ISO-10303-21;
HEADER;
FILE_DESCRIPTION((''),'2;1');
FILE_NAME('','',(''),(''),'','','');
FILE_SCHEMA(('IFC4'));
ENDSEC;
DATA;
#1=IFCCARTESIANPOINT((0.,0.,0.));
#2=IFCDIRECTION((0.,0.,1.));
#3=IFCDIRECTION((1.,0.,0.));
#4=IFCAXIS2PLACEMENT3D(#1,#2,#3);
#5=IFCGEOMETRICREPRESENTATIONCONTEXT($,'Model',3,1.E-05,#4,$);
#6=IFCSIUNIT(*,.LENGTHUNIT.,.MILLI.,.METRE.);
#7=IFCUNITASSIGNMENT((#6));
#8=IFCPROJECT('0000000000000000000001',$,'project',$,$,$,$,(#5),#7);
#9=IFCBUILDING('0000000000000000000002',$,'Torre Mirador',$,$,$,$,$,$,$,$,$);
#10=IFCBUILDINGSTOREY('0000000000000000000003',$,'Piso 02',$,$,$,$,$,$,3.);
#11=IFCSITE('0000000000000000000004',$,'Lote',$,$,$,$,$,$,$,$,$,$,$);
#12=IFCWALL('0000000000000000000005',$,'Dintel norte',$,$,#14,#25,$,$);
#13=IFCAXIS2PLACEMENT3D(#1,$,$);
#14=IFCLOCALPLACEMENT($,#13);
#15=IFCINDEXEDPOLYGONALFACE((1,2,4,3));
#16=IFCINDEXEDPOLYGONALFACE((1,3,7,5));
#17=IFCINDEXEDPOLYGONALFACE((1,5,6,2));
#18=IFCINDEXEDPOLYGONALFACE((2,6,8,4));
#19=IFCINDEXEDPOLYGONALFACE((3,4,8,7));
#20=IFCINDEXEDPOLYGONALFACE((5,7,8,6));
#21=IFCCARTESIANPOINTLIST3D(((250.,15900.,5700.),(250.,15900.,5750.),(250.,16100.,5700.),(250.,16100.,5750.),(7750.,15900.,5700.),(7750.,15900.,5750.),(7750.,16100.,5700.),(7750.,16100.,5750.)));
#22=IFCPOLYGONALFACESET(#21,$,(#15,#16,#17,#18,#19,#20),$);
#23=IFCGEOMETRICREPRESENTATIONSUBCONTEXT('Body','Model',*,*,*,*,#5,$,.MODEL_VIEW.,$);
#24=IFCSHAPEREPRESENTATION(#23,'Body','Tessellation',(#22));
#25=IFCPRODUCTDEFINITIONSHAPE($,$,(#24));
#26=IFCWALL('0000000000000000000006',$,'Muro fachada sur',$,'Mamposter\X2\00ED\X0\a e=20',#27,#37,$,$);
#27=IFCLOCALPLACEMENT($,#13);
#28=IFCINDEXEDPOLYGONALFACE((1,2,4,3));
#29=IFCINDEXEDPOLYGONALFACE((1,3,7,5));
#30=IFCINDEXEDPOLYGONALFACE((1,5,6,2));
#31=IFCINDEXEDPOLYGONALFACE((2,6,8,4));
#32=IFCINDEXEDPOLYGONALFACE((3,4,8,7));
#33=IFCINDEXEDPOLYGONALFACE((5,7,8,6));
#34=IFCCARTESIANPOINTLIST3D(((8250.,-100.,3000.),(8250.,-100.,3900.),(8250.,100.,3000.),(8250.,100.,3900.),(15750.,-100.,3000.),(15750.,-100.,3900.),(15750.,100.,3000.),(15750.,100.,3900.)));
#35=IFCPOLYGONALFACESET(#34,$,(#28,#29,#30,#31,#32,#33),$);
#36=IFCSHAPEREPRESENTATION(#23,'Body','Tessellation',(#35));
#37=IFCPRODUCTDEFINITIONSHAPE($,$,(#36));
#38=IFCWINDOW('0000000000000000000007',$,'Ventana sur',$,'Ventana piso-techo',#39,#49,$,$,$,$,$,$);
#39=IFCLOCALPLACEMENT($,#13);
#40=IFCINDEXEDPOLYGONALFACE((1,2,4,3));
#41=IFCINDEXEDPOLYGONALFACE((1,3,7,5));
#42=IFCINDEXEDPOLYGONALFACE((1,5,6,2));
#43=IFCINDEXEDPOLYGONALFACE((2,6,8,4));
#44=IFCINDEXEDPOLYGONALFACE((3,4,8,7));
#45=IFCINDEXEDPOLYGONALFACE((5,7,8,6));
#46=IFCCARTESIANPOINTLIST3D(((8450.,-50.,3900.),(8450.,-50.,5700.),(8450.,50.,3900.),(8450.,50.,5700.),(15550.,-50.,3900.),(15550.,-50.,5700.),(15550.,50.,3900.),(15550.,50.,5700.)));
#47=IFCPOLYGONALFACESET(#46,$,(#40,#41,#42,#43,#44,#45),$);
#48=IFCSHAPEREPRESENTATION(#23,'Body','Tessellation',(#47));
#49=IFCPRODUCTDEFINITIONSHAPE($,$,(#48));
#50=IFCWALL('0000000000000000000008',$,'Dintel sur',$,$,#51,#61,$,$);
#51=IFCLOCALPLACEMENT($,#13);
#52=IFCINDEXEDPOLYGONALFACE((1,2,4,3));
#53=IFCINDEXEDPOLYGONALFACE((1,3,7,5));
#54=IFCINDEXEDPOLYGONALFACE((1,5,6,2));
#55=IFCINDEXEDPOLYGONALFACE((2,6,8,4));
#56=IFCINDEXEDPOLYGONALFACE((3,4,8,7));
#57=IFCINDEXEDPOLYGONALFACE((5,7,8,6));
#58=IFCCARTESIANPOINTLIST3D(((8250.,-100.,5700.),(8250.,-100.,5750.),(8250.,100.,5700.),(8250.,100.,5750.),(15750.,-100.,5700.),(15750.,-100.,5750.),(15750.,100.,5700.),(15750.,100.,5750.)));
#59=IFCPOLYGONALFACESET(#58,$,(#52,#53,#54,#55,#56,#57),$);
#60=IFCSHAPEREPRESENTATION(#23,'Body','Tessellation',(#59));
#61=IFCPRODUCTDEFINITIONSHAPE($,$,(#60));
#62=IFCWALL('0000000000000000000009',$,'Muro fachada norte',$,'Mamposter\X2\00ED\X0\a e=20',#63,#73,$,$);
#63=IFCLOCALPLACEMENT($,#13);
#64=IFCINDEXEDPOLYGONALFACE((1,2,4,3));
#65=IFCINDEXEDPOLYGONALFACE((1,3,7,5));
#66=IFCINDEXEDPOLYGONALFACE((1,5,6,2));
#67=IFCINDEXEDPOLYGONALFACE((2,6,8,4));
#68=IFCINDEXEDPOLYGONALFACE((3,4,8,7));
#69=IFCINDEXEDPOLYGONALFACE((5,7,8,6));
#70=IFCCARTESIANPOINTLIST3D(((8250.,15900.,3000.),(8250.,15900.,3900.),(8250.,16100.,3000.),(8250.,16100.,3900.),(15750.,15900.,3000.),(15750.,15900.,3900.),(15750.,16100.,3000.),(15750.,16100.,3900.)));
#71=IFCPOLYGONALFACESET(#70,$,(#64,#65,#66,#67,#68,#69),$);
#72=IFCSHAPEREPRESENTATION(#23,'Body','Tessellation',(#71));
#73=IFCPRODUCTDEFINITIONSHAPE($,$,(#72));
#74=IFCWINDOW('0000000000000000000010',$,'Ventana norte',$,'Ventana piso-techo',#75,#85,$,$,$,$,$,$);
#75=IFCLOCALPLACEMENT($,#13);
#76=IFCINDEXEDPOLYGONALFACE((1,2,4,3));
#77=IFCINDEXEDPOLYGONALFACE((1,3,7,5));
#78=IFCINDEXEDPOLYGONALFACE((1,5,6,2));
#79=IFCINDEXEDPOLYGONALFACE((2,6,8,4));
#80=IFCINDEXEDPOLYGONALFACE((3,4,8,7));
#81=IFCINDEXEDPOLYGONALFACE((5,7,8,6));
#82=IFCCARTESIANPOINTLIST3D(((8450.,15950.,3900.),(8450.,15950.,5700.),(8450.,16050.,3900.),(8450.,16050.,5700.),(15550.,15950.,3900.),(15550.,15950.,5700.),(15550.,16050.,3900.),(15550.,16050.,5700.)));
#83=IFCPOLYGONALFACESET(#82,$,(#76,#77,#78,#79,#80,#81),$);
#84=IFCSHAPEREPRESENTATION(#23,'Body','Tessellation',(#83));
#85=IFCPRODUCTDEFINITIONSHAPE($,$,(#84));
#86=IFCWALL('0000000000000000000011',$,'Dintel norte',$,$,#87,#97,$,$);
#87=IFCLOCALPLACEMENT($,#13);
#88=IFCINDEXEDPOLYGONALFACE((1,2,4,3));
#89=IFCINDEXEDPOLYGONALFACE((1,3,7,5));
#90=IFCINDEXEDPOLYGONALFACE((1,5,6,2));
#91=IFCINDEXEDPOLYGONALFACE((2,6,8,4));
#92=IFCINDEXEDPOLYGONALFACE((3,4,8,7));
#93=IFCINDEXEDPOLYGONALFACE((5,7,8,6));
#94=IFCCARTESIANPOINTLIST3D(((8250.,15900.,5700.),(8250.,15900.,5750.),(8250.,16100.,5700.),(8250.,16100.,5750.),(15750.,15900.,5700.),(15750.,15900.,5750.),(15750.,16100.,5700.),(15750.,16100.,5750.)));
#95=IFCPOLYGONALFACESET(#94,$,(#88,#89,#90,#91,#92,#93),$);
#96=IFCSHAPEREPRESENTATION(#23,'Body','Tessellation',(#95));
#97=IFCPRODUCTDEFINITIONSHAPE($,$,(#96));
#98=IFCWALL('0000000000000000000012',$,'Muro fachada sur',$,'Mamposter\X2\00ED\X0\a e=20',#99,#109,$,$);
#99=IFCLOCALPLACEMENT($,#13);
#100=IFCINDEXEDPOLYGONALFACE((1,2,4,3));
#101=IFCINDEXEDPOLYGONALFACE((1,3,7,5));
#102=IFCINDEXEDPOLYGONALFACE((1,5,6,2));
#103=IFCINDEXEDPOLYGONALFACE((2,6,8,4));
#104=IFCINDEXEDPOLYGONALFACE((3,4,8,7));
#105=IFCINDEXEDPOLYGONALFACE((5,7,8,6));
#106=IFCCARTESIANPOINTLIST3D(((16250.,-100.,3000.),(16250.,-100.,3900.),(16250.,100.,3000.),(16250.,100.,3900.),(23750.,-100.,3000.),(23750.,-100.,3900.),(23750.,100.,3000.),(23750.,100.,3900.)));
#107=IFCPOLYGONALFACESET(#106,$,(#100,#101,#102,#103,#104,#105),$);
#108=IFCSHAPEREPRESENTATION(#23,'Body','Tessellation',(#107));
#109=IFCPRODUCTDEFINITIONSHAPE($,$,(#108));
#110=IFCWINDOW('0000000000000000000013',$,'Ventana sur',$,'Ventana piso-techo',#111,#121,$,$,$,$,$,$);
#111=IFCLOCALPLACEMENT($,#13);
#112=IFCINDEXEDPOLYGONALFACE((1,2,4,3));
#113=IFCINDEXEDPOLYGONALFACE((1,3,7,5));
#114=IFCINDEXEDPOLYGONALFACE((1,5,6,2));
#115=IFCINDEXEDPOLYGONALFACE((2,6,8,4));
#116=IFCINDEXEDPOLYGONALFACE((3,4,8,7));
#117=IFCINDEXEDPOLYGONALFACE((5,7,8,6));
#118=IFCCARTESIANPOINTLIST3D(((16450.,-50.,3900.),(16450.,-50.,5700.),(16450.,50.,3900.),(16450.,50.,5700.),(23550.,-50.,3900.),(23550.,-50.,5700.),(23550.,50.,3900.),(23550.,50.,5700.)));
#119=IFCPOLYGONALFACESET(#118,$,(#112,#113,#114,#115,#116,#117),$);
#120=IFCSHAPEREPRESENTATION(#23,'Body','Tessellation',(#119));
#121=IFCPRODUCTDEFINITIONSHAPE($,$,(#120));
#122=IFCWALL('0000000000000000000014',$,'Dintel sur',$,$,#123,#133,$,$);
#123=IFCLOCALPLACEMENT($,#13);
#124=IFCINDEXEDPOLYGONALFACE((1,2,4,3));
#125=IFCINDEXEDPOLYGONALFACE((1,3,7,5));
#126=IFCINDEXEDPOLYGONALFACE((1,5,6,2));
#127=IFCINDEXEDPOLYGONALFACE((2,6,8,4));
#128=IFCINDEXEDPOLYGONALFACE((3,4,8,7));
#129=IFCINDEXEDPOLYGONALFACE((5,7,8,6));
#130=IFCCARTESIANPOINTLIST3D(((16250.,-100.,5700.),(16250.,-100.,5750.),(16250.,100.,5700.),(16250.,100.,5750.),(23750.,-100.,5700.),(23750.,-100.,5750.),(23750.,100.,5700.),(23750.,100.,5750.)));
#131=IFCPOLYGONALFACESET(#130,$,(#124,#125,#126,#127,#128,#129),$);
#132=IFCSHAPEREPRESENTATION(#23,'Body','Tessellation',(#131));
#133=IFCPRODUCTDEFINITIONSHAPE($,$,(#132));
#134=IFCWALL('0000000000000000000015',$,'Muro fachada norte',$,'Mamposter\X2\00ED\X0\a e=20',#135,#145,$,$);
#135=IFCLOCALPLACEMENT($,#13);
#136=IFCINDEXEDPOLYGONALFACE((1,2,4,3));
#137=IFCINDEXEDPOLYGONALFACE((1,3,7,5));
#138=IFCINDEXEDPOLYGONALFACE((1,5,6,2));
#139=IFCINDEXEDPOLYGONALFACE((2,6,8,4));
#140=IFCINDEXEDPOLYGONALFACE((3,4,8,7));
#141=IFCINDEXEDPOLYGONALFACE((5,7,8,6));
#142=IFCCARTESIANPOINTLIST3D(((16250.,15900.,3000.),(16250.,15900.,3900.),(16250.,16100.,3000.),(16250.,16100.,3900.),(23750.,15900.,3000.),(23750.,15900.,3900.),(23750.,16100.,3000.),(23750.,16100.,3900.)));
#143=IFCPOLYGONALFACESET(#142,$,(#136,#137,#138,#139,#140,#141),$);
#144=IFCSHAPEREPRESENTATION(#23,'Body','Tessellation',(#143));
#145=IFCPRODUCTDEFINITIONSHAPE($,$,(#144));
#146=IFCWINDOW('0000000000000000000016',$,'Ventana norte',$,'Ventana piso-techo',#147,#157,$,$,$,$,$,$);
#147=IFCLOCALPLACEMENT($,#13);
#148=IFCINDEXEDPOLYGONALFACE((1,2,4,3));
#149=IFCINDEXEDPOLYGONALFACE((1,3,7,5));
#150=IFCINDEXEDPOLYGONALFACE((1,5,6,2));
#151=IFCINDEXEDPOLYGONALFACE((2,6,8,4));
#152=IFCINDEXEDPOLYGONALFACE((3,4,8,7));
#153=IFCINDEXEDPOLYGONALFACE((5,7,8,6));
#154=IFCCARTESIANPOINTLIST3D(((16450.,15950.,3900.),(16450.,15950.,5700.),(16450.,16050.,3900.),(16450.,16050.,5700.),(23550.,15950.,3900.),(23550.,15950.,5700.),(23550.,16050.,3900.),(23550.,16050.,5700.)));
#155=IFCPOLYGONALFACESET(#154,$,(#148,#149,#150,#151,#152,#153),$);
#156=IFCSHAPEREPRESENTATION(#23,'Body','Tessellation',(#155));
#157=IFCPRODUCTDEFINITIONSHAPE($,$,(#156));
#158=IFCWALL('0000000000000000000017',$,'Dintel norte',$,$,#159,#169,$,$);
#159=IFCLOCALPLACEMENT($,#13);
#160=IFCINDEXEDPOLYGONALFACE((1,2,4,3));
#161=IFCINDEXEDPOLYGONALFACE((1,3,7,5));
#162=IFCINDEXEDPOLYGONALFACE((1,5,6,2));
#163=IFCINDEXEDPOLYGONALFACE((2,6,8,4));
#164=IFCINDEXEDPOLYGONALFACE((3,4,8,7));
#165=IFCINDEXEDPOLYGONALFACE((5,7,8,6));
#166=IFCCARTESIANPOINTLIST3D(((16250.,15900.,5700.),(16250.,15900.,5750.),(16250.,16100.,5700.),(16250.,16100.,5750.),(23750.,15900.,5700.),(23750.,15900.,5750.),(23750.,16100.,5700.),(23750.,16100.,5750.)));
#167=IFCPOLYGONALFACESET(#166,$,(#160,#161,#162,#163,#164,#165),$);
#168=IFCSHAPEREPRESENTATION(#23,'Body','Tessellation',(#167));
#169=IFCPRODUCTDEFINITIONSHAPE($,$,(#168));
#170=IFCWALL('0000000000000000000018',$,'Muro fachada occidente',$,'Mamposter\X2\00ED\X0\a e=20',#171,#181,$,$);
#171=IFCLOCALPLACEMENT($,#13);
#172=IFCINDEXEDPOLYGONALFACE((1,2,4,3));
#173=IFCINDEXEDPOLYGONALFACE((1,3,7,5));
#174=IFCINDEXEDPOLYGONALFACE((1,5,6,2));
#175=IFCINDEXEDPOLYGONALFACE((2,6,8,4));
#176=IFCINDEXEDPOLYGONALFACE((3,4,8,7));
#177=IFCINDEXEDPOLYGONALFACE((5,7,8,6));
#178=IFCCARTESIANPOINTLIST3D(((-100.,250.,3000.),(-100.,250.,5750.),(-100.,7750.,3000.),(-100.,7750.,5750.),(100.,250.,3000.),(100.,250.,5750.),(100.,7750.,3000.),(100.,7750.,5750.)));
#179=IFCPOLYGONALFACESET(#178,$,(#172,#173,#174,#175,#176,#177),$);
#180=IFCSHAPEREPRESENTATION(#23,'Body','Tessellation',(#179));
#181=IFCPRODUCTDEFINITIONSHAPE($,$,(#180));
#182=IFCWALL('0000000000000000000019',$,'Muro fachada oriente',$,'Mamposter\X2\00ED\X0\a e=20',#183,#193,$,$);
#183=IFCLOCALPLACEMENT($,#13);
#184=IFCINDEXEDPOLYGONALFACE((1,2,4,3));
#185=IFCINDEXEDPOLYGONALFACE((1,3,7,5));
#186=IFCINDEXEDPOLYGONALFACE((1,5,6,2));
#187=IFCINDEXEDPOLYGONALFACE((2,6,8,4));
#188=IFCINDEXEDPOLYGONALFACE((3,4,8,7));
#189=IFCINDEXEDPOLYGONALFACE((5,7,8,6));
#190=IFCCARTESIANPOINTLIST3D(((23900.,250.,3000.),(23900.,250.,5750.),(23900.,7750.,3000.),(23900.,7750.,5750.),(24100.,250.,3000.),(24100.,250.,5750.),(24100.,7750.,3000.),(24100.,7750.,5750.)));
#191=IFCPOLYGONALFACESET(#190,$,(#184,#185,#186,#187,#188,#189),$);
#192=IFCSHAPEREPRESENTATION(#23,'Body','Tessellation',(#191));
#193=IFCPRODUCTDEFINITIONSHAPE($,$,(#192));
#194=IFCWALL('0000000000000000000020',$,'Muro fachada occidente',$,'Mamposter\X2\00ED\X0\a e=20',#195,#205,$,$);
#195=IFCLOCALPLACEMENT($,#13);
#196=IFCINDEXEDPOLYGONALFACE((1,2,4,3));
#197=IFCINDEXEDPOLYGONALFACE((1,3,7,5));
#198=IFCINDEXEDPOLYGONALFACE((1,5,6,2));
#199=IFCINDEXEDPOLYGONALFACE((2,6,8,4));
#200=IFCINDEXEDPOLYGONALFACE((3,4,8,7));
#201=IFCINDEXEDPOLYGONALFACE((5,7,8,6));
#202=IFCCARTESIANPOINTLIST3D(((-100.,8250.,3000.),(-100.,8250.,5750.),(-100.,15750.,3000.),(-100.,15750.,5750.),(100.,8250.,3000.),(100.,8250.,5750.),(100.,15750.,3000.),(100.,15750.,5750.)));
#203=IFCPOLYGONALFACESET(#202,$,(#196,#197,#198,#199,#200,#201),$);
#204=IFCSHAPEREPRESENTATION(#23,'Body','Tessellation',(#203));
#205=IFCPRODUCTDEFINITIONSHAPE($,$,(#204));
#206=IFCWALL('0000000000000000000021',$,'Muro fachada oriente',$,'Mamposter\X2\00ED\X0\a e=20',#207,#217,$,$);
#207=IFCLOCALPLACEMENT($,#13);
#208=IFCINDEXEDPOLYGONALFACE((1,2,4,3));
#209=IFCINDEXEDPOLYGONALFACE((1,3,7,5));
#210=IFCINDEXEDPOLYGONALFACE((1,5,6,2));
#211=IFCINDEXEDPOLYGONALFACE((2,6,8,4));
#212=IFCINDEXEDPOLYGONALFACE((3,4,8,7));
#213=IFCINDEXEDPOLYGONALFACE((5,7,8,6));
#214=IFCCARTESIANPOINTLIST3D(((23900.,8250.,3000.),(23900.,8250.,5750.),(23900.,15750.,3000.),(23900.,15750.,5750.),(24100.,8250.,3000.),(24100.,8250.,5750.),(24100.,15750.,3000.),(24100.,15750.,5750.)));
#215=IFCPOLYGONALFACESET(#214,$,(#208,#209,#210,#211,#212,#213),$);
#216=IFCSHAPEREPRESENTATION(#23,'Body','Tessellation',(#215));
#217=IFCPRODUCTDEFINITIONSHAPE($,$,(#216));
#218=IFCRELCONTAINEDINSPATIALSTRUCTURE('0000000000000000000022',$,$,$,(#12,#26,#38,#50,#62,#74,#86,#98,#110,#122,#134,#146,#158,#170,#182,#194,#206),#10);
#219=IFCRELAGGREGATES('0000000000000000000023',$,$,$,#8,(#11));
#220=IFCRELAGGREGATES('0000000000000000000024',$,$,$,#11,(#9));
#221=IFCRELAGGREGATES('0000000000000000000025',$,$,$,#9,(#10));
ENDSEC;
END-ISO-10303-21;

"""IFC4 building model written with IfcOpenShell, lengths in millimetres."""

from ifc_helpers import new_model, si_unit, frame, origin_with_axes, place, context, subcontext, project, spatial, indexed_curve, outline, extrude, element, save


model = new_model("IFC4")

# Units and contexts
model_context = context("Model", 3, precision=1e-05, world=origin_with_axes())
body_context = subcontext(model_context, "Body", "Model", "MODEL_VIEW")
ifc_project = project(units=[si_unit("LENGTHUNIT", "METRE", prefix="MILLI")], contexts=[model_context])

# Site, building, storey
site = spatial("IfcSite", under=ifc_project, Name="Lote")
building = spatial("IfcBuilding", under=site, Name="Torre Mirador")
storey = spatial("IfcBuildingStorey", under=building, Name="Piso 02", Elevation=3.0)

# Walls
wall_1_placement = place(None, frame((250.0, 15900.0, 5700.0), z_axis=(0.0, 0.0, 1.0), x_axis=(1.0, 0.0, 0.0)))
element("IfcWall", 1, at=wall_1_placement, inside=storey, Name="Dintel norte", context=body_context, shape_type="SweptSolid", body=[
    extrude(outline(indexed_curve([(0.0, 0.0), (0.0, 200.0), (7500.0, 200.0), (7500.0, 0.0), (0.0, 0.0)], self_intersect=False)), origin_with_axes(), (0.0, 0.0, 1.0), 50.0),
])
wall_2_placement = place(None, frame((8250.0, -100.0, 3000.0), z_axis=(0.0, 0.0, 1.0), x_axis=(1.0, 0.0, 0.0)))
element("IfcWall", 2, at=wall_2_placement, inside=storey, Name="Muro fachada sur", ObjectType="Mampostería e=20", context=body_context, shape_type="SweptSolid", body=[
    extrude(outline(indexed_curve([(0.0, 0.0), (0.0, 200.0), (7500.0, 200.0), (7500.0, 0.0), (0.0, 0.0)], self_intersect=False)), origin_with_axes(), (0.0, 0.0, 1.0), 900.0),
])

# Window
window_1_placement = place(None, frame((8450.0, -50.0, 3900.0), z_axis=(0.0, 0.0, 1.0), x_axis=(1.0, 0.0, 0.0)))
element("IfcWindow", 3, at=window_1_placement, inside=storey, Name="Ventana sur", ObjectType="Ventana piso-techo", context=body_context, shape_type="SweptSolid", body=[
    extrude(outline(indexed_curve([(0.0, 0.0), (0.0, 100.0), (7100.0, 100.0), (7100.0, 0.0), (0.0, 0.0)], self_intersect=False)), origin_with_axes(), (0.0, 0.0, 1.0), 1800.0),
])

# Walls
wall_3_placement = place(None, frame((8250.0, -100.0, 5700.0), z_axis=(0.0, 0.0, 1.0), x_axis=(1.0, 0.0, 0.0)))
element("IfcWall", 4, at=wall_3_placement, inside=storey, Name="Dintel sur", context=body_context, shape_type="SweptSolid", body=[
    extrude(outline(indexed_curve([(0.0, 0.0), (0.0, 200.0), (7500.0, 200.0), (7500.0, 0.0), (0.0, 0.0)], self_intersect=False)), origin_with_axes(), (0.0, 0.0, 1.0), 50.0),
])
wall_4_placement = place(None, frame((8250.0, 15900.0, 3000.0), z_axis=(0.0, 0.0, 1.0), x_axis=(1.0, 0.0, 0.0)))
element("IfcWall", 5, at=wall_4_placement, inside=storey, Name="Muro fachada norte", ObjectType="Mampostería e=20", context=body_context, shape_type="SweptSolid", body=[
    extrude(outline(indexed_curve([(0.0, 0.0), (0.0, 200.0), (7500.0, 200.0), (7500.0, 0.0), (0.0, 0.0)], self_intersect=False)), origin_with_axes(), (0.0, 0.0, 1.0), 900.0),
])

# Window
window_2_placement = place(None, frame((8450.0, 15950.0, 3900.0), z_axis=(0.0, 0.0, 1.0), x_axis=(1.0, 0.0, 0.0)))
element("IfcWindow", 6, at=window_2_placement, inside=storey, Name="Ventana norte", ObjectType="Ventana piso-techo", context=body_context, shape_type="SweptSolid", body=[
    extrude(outline(indexed_curve([(0.0, 0.0), (0.0, 100.0), (7100.0, 100.0), (7100.0, 0.0), (0.0, 0.0)], self_intersect=False)), origin_with_axes(), (0.0, 0.0, 1.0), 1800.0),
])

# Walls
wall_5_placement = place(None, frame((8250.0, 15900.0, 5700.0), z_axis=(0.0, 0.0, 1.0), x_axis=(1.0, 0.0, 0.0)))
element("IfcWall", 7, at=wall_5_placement, inside=storey, Name="Dintel norte", context=body_context, shape_type="SweptSolid", body=[
    extrude(outline(indexed_curve([(0.0, 0.0), (0.0, 200.0), (7500.0, 200.0), (7500.0, 0.0), (0.0, 0.0)], self_intersect=False)), origin_with_axes(), (0.0, 0.0, 1.0), 50.0),
])
wall_6_placement = place(None, frame((16250.0, -100.0, 3000.0), z_axis=(0.0, 0.0, 1.0), x_axis=(1.0, 0.0, 0.0)))
element("IfcWall", 8, at=wall_6_placement, inside=storey, Name="Muro fachada sur", ObjectType="Mampostería e=20", context=body_context, shape_type="SweptSolid", body=[
    extrude(outline(indexed_curve([(0.0, 0.0), (0.0, 200.0), (7500.0, 200.0), (7500.0, 0.0), (0.0, 0.0)], self_intersect=False)), origin_with_axes(), (0.0, 0.0, 1.0), 900.0),
])

# Window
window_3_placement = place(None, frame((16450.0, -50.0, 3900.0), z_axis=(0.0, 0.0, 1.0), x_axis=(1.0, 0.0, 0.0)))
element("IfcWindow", 9, at=window_3_placement, inside=storey, Name="Ventana sur", ObjectType="Ventana piso-techo", context=body_context, shape_type="SweptSolid", body=[
    extrude(outline(indexed_curve([(0.0, 0.0), (0.0, 100.0), (7100.0, 100.0), (7100.0, 0.0), (0.0, 0.0)], self_intersect=False)), origin_with_axes(), (0.0, 0.0, 1.0), 1800.0),
])

# Walls
wall_7_placement = place(None, frame((16250.0, -100.0, 5700.0), z_axis=(0.0, 0.0, 1.0), x_axis=(1.0, 0.0, 0.0)))
element("IfcWall", 10, at=wall_7_placement, inside=storey, Name="Dintel sur", context=body_context, shape_type="SweptSolid", body=[
    extrude(outline(indexed_curve([(0.0, 0.0), (0.0, 200.0), (7500.0, 200.0), (7500.0, 0.0), (0.0, 0.0)], self_intersect=False)), origin_with_axes(), (0.0, 0.0, 1.0), 50.0),
])
wall_8_placement = place(None, frame((16250.0, 15900.0, 3000.0), z_axis=(0.0, 0.0, 1.0), x_axis=(1.0, 0.0, 0.0)))
element("IfcWall", 11, at=wall_8_placement, inside=storey, Name="Muro fachada norte", ObjectType="Mampostería e=20", context=body_context, shape_type="SweptSolid", body=[
    extrude(outline(indexed_curve([(0.0, 0.0), (0.0, 200.0), (7500.0, 200.0), (7500.0, 0.0), (0.0, 0.0)], self_intersect=False)), origin_with_axes(), (0.0, 0.0, 1.0), 900.0),
])

# Window
window_4_placement = place(None, frame((16450.0, 15950.0, 3900.0), z_axis=(0.0, 0.0, 1.0), x_axis=(1.0, 0.0, 0.0)))
element("IfcWindow", 12, at=window_4_placement, inside=storey, Name="Ventana norte", ObjectType="Ventana piso-techo", context=body_context, shape_type="SweptSolid", body=[
    extrude(outline(indexed_curve([(0.0, 0.0), (0.0, 100.0), (7100.0, 100.0), (7100.0, 0.0), (0.0, 0.0)], self_intersect=False)), origin_with_axes(), (0.0, 0.0, 1.0), 1800.0),
])

# Walls
wall_9_placement = place(None, frame((16250.0, 15900.0, 5700.0), z_axis=(0.0, 0.0, 1.0), x_axis=(1.0, 0.0, 0.0)))
element("IfcWall", 13, at=wall_9_placement, inside=storey, Name="Dintel norte", context=body_context, shape_type="SweptSolid", body=[
    extrude(outline(indexed_curve([(0.0, 0.0), (0.0, 200.0), (7500.0, 200.0), (7500.0, 0.0), (0.0, 0.0)], self_intersect=False)), origin_with_axes(), (0.0, 0.0, 1.0), 50.0),
])
for number, where, z_axis, x_axis, name in (
    (14, (-100.0, 250.0, 3000.0), (0.0, 0.0, 1.0), (1.0, 0.0, 0.0), "Muro fachada occidente"),
    (15, (23900.0, 250.0, 3000.0), (0.0, 0.0, 1.0), (1.0, 0.0, 0.0), "Muro fachada oriente"),
    (16, (-100.0, 8250.0, 3000.0), (0.0, 0.0, 1.0), (1.0, 0.0, 0.0), "Muro fachada occidente"),
    (17, (23900.0, 8250.0, 3000.0), (0.0, 0.0, 1.0), (1.0, 0.0, 0.0), "Muro fachada oriente"),
):
    element("IfcWall", number, at=place(None, frame(where, z_axis=z_axis, x_axis=x_axis)), inside=storey, Name=name, ObjectType="Mampostería e=20", context=body_context, shape_type="SweptSolid", body=[
        extrude(outline(indexed_curve([(0.0, 0.0), (0.0, 7500.0), (200.0, 7500.0), (200.0, 0.0), (0.0, 0.0)], self_intersect=False)), origin_with_axes(), (0.0, 0.0, 1.0), 2750.0),
    ])

save(model, "model.ifc")
